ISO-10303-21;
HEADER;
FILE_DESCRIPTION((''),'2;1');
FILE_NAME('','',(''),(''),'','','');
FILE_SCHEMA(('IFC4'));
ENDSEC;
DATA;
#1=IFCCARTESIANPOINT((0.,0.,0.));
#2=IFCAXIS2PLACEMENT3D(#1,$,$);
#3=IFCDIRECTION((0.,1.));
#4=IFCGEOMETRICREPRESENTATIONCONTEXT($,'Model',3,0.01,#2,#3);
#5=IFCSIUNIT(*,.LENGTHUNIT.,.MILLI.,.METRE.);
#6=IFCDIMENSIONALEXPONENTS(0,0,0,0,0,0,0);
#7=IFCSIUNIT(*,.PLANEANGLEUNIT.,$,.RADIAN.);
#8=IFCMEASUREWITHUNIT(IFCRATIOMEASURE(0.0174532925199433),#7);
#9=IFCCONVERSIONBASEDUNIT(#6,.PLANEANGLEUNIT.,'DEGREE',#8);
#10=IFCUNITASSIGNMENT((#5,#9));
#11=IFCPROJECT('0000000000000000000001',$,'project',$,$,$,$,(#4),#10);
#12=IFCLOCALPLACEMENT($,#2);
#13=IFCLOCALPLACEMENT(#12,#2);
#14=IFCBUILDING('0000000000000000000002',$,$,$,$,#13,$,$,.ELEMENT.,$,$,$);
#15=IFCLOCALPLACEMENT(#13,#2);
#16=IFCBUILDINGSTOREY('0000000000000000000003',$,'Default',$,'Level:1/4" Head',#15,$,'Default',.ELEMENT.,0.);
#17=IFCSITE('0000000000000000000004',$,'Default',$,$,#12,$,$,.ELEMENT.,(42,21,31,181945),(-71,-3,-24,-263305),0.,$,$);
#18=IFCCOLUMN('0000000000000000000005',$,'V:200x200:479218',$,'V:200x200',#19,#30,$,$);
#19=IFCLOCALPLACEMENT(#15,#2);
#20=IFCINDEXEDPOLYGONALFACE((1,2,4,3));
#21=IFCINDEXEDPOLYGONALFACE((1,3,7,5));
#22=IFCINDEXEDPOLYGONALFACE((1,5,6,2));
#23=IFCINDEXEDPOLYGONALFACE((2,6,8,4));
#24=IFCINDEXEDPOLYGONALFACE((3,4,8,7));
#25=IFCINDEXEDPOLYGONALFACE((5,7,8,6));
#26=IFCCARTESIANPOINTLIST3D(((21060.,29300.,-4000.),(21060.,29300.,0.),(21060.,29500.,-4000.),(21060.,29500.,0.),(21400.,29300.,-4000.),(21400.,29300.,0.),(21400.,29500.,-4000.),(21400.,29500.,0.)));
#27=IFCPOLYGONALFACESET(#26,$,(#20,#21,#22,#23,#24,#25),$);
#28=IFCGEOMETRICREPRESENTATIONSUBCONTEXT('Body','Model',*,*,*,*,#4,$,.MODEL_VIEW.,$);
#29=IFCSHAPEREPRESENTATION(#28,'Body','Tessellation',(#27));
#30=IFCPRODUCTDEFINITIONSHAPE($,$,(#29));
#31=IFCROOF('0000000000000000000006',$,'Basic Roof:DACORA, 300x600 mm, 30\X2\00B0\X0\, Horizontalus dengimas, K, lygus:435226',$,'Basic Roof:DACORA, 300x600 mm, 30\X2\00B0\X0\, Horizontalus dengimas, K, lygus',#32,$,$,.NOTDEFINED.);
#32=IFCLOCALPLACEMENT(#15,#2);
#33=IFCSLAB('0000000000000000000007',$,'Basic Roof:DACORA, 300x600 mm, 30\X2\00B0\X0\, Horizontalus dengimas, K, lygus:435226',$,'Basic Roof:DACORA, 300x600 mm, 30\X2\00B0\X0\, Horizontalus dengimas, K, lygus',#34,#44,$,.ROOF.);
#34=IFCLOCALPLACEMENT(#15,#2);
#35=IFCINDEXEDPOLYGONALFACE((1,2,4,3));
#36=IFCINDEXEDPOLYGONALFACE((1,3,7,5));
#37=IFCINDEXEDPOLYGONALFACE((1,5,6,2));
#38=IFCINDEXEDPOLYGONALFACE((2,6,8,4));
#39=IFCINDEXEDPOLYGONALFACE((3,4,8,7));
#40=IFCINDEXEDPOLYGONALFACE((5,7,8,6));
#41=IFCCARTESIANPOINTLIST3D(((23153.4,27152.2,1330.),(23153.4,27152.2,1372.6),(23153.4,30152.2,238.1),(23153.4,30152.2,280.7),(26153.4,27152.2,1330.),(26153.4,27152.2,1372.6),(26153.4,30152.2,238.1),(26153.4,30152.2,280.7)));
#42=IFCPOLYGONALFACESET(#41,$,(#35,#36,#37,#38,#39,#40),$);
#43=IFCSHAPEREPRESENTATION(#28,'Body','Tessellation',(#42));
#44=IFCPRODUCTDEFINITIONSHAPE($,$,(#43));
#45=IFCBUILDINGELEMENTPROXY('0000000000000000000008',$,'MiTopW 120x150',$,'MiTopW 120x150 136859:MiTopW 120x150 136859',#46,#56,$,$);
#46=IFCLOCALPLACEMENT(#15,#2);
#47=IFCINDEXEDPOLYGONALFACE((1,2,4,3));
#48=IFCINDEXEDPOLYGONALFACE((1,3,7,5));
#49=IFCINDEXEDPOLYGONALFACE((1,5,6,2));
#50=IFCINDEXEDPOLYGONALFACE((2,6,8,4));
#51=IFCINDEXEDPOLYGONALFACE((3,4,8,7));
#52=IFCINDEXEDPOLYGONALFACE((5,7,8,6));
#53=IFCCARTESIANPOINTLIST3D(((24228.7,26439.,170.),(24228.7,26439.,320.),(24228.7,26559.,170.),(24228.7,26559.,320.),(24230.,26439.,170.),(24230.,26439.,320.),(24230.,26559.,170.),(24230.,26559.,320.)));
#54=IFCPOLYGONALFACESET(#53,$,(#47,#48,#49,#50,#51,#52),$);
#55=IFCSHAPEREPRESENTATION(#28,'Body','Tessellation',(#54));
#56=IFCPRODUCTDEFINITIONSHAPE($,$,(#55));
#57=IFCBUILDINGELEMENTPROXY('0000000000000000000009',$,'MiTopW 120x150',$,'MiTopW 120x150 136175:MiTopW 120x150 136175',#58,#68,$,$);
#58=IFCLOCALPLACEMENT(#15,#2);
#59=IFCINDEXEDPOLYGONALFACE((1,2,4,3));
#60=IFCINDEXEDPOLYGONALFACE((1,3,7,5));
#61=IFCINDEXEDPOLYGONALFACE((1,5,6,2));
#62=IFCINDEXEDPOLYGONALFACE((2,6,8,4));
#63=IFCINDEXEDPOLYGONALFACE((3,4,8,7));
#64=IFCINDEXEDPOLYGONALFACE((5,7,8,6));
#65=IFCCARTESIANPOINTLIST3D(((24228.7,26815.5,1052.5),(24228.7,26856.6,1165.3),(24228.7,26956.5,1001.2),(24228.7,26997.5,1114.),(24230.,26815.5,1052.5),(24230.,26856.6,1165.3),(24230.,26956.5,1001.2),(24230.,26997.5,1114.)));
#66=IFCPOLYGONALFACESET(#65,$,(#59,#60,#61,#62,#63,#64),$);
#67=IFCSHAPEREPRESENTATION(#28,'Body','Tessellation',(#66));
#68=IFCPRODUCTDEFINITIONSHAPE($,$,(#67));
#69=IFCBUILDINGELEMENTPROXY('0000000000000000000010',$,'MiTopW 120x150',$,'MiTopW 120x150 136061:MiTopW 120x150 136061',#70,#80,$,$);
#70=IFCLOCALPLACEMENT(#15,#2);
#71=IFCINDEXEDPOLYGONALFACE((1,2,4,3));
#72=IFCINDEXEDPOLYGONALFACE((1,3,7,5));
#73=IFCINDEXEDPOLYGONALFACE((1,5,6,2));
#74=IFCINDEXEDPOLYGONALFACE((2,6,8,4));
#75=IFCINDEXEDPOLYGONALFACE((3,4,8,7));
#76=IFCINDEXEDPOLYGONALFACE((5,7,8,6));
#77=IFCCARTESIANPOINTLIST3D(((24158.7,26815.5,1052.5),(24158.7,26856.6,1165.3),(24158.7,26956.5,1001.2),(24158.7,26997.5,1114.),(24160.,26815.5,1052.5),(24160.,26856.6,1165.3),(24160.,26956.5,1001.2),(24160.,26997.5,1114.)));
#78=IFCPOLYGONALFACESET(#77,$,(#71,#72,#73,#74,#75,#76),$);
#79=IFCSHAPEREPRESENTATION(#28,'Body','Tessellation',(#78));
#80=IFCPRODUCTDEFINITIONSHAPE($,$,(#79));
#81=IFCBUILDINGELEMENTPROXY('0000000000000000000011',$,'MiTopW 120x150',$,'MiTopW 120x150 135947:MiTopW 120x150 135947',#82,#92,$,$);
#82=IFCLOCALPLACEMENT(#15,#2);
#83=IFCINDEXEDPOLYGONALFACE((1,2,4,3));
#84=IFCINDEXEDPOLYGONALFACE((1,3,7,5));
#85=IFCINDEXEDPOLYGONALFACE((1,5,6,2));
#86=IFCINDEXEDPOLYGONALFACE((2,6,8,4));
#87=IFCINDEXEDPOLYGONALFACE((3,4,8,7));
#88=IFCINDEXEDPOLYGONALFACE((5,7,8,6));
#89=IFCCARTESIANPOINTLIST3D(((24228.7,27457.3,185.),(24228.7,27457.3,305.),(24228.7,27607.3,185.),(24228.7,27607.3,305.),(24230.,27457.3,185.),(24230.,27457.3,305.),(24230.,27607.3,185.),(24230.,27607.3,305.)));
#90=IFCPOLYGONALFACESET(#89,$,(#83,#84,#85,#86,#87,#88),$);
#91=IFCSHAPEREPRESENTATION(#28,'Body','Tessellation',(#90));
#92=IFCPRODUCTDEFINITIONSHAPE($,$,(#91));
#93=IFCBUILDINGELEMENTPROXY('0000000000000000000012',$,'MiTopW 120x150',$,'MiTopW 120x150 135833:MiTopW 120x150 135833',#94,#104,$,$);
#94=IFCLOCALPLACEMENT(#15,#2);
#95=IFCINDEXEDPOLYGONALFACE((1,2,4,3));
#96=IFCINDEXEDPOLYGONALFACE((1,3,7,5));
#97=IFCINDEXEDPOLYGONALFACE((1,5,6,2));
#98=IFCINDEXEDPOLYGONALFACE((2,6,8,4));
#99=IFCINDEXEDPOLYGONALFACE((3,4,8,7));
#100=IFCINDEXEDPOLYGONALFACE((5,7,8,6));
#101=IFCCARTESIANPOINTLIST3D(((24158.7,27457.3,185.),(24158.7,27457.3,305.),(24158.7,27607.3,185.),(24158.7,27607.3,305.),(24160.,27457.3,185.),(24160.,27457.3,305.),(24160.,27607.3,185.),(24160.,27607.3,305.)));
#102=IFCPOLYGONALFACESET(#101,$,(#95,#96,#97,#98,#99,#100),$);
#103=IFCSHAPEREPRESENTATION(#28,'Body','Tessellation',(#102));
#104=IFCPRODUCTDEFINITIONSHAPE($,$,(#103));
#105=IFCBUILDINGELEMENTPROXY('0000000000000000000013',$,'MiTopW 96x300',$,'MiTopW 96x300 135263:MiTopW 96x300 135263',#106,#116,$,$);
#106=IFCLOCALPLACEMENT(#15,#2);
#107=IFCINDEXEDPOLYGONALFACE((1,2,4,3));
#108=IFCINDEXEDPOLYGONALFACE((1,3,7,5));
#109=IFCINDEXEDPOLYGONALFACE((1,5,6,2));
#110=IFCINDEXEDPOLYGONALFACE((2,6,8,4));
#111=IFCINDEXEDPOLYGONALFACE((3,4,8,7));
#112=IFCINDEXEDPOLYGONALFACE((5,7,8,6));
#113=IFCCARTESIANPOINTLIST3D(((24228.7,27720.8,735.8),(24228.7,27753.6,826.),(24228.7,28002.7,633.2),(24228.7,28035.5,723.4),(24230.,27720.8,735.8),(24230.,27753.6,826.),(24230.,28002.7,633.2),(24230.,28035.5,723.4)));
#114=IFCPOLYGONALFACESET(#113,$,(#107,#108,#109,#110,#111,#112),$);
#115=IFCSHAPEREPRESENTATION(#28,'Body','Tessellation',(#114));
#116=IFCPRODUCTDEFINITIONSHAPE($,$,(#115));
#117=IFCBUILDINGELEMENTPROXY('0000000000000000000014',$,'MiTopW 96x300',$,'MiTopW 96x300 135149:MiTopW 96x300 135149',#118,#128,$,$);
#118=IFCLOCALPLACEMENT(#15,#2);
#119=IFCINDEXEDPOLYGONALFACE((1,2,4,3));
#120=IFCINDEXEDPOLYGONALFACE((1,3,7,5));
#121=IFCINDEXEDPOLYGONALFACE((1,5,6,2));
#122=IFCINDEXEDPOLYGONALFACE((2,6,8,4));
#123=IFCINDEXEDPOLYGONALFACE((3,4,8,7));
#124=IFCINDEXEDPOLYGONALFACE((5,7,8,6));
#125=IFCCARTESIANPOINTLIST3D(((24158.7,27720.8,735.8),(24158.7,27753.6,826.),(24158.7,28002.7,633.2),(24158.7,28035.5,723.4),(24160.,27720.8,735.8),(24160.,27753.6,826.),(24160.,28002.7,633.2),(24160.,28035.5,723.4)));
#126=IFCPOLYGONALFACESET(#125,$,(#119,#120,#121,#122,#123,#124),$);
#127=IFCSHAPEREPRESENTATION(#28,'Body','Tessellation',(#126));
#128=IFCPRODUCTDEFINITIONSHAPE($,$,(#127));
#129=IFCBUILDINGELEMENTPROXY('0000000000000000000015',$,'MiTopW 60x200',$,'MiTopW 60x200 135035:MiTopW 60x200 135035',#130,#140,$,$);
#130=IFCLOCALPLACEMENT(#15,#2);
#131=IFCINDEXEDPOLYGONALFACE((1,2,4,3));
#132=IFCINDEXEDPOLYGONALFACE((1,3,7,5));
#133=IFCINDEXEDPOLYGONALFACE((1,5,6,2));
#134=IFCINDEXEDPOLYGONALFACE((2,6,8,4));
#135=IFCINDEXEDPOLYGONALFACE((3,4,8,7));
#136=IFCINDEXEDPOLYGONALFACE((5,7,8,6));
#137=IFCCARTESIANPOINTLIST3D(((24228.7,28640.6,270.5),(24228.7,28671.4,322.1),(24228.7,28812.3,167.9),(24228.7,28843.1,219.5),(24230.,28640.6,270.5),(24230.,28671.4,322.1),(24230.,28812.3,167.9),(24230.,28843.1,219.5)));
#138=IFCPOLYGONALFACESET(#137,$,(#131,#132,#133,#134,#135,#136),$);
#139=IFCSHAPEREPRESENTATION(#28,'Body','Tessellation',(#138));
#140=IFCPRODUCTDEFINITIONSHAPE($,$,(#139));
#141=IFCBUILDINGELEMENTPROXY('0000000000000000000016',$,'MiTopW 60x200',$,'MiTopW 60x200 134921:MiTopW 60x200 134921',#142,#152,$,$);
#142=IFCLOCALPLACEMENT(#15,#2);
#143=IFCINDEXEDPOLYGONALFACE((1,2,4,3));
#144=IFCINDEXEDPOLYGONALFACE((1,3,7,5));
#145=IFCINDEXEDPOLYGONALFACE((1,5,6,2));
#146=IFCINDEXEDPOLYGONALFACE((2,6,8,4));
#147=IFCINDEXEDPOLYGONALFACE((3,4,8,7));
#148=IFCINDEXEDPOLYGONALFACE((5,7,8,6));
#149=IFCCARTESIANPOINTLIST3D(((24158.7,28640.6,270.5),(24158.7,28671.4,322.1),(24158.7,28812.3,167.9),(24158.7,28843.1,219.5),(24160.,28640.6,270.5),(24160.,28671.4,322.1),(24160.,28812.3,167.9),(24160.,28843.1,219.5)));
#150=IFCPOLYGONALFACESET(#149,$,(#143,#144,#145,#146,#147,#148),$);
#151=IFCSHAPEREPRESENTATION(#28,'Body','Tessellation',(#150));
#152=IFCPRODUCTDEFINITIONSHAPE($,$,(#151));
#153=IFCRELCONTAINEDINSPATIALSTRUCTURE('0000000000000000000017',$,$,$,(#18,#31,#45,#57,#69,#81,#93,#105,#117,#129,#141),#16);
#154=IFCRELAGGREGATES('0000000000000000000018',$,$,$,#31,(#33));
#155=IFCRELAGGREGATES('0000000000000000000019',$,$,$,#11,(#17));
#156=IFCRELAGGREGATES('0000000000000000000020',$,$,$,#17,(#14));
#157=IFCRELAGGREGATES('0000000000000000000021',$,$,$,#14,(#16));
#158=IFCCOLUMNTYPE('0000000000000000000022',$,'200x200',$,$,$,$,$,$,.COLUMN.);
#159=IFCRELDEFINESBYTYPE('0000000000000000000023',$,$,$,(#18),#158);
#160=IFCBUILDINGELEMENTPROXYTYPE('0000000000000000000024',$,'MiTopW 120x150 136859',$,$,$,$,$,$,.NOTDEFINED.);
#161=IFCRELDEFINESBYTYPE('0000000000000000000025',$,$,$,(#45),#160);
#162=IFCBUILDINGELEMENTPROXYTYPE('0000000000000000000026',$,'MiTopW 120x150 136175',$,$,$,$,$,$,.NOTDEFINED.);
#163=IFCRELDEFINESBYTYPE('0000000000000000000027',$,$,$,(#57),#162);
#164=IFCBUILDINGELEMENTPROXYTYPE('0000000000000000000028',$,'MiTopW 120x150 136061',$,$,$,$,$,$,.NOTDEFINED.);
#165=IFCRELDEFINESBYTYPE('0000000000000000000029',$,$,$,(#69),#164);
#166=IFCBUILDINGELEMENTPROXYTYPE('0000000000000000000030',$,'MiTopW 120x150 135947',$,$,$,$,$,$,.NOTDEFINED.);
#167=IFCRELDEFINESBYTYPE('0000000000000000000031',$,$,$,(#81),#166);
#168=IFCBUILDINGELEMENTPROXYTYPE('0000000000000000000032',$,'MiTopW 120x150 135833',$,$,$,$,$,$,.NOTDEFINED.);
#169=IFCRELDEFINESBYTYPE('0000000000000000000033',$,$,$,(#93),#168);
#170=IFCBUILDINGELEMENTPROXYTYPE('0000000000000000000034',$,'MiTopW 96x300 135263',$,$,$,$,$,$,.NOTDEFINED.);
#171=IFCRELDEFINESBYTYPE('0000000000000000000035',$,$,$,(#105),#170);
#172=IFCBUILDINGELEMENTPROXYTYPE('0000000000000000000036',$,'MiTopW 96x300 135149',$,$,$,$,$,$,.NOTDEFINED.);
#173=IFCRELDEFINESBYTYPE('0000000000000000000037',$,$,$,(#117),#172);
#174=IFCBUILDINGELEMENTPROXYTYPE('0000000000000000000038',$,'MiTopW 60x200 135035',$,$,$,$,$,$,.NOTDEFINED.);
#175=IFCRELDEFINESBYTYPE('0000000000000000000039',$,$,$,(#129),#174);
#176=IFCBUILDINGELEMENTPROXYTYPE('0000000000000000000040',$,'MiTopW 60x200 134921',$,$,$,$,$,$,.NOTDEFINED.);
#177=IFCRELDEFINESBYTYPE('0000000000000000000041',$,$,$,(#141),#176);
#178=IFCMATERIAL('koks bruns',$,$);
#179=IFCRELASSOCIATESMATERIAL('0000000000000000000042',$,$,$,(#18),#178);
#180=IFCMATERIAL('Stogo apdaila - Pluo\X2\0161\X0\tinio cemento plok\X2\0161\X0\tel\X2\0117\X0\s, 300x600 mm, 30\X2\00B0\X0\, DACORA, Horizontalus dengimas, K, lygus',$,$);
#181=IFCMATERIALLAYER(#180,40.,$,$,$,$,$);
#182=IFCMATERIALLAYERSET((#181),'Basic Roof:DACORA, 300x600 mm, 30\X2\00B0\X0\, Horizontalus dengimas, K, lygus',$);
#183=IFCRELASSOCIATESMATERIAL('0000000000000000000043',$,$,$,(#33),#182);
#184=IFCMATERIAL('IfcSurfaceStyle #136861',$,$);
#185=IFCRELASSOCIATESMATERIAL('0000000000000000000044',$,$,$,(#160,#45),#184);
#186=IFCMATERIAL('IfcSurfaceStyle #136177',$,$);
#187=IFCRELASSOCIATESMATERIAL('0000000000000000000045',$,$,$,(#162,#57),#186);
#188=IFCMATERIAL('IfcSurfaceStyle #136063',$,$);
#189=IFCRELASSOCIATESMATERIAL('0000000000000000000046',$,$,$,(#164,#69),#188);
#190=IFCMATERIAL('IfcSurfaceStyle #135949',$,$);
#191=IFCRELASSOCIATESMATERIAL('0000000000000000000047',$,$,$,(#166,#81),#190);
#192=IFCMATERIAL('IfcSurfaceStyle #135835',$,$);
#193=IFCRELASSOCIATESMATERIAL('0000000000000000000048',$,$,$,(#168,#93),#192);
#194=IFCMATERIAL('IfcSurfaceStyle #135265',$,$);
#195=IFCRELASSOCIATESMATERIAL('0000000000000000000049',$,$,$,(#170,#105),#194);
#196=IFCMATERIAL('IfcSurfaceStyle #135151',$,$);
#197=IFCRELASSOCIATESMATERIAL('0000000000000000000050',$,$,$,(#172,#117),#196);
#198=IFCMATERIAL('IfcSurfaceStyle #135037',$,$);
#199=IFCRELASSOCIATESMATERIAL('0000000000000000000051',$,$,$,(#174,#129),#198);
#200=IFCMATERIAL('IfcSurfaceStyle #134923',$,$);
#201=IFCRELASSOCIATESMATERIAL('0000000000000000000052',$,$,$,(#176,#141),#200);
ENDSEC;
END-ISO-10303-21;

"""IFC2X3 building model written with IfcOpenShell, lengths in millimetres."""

from ifc_helpers import new_model, entity, si_unit, converted_unit, direction, frame, frame_2d, origin, origin_2d_with_axis, place, context, subcontext, project, spatial, polyline, rectangle, outline, extrude, source, transform, mapped, material, layer, layer_set, type_object, type_shapes, element, aggregate, save


model = new_model("IFC2X3")

# Units and contexts
model_context = context("Model", 3, precision=0.01, world=origin(), true_north=direction((0.0, 1.0)))
body_context = subcontext(model_context, "Body", "Model", "MODEL_VIEW")
ifc_project = project(units=[si_unit("LENGTHUNIT", "METRE", prefix="MILLI"), converted_unit("PLANEANGLEUNIT", "DEGREE", entity("IfcRatioMeasure", 0.0174532925199433), si_unit("PLANEANGLEUNIT", "RADIAN"), dimensions=[0, 0, 0, 0, 0, 0, 0])], contexts=[model_context])

# Site, building, storey
site_placement = place(None, origin())
site = spatial("IfcSite", under=ifc_project, at=site_placement, Name="Default", CompositionType="ELEMENT", RefLatitude=(42, 21, 31, 181945), RefLongitude=(-71, -3, -24, -263305), RefElevation=0.0)
building_placement = place(site_placement, origin())
building = spatial("IfcBuilding", under=site, at=building_placement, CompositionType="ELEMENT")
storey_placement = place(building_placement, origin())
storey = spatial("IfcBuildingStorey", under=building, at=storey_placement, Name="Default", ObjectType="Level:1/4\" Head", LongName="Default", CompositionType="ELEMENT", Elevation=0.0)

# Column
ifc_material_1 = material(Name="koks bruns")
column_type = type_object("IfcColumnType", Name="200x200", PredefinedType="COLUMN")
shared_shape_1 = source(origin(), body_context, "Body", "SweptSolid", [
    extrude(rectangle(XDim=340.0, YDim=200.0, at=origin_2d_with_axis()), frame((100.0, 280.0, -4000.0), z_axis=(0.0, 0.0, 1.0), x_axis=(0.0, -1.0, 0.0)), (0.0, 0.0, 1.0), 4000.0),
])
type_shapes(column_type, [shared_shape_1])
column_placement = place(storey_placement, frame((21510.0, 29300.0, 0.0), z_axis=(0.0, 0.0, 1.0), x_axis=(0.0, 1.0, 0.0)))
element("IfcColumn", 1, at=column_placement, inside=storey, type_object=column_type, material=ifc_material_1, Name="V:200x200:479218", ObjectType="V:200x200", context=body_context, shape_type="MappedRepresentation", body=[
    mapped(shared_shape_1, transform((0.0, 0.0, 0.0), scale=1.0)),
])

# Roof, slab
roof_placement = place(storey_placement, frame((23153.4, 27152.2, 238.1)))
roof = element("IfcRoof", 2, at=roof_placement, inside=storey, Name="Basic Roof:DACORA, 300x600 mm, 30°, Horizontalus dengimas, K, lygus:435226", ObjectType="Basic Roof:DACORA, 300x600 mm, 30°, Horizontalus dengimas, K, lygus", ShapeType="NOTDEFINED")
ifc_material_2 = material(Name="Stogo apdaila - Pluoštinio cemento plokštelės, 300x600 mm, 30°, DACORA, Horizontalus dengimas, K, lygus")
ifc_layer = layer(ifc_material_2, 40.0)
ifc_layer_set = layer_set([ifc_layer], Name="Basic Roof:DACORA, 300x600 mm, 30°, Horizontalus dengimas, K, lygus")
slab_placement = place(roof_placement, origin())
slab = element("IfcSlab", 3, at=slab_placement, material=ifc_layer_set, Name="Basic Roof:DACORA, 300x600 mm, 30°, Horizontalus dengimas, K, lygus:435226", ObjectType="Basic Roof:DACORA, 300x600 mm, 30°, Horizontalus dengimas, K, lygus", PredefinedType="ROOF", context=body_context, shape_type="SweptSolid", body=[
    extrude(rectangle(XDim=3192.5, YDim=3000.0, at=frame_2d((0.0, 0.0), x_axis=(0.0, 1.0))), frame((1500.0, 1500.0, 546.0), z_axis=(0.0, 0.34202, 0.939693), x_axis=(1.0, 0.0, 0.0)), (0.0, -0.34202, 0.939693), 42.6),
])
aggregate(roof, [slab])

# Building element proxies
ifc_material_3 = material(Name="IfcSurfaceStyle #136861")
building_element_proxy_type_1 = type_object("IfcBuildingElementProxyType", Name="MiTopW 120x150 136859", PredefinedType="NOTDEFINED", material=ifc_material_3)
shared_shape_2 = source(origin(), body_context, "Body", "SweptSolid", [
    extrude(rectangle(XDim=150.0, YDim=120.0, at=frame_2d((0.0, 0.0), x_axis=(1.0, 0.0))), frame((75.0, 60.0, 0.0), z_axis=(0.0, 0.0, 1.0), x_axis=(-1.0, 0.0, 0.0)), (0.0, 0.0, 1.0), 1.3),
])
type_shapes(building_element_proxy_type_1, [shared_shape_2])
proxy_1_placement = place(building_placement, frame((24230.0, 26439.0, 170.0), z_axis=(-1.0, 0.0, 0.0), x_axis=(0.0, 0.0, 1.0)))
element("IfcBuildingElementProxy", 4, at=proxy_1_placement, inside=storey, type_object=building_element_proxy_type_1, material=ifc_material_3, Name="MiTopW 120x150", ObjectType="MiTopW 120x150 136859:MiTopW 120x150 136859", context=body_context, shape_type="MappedRepresentation", body=[
    mapped(shared_shape_2, transform((0.0, 0.0, 0.0), scale=1.0)),
])
ifc_material_4 = material(Name="IfcSurfaceStyle #136177")
building_element_proxy_type_2 = type_object("IfcBuildingElementProxyType", Name="MiTopW 120x150 136175", PredefinedType="NOTDEFINED", material=ifc_material_4)
shared_shape_3 = source(origin(), body_context, "Body", "SweptSolid", [
    extrude(outline(polyline([(-75.0, -60.0), (75.0, -60.0), (75.0, 60.0), (-75.0, 60.0), (-75.0, -60.0)])), frame((75.0, 60.0, 0.0), z_axis=(0.0, 0.0, 1.0), x_axis=(-1.0, 0.0, 0.0)), (0.0, 0.0, 1.0), 1.3),
])
type_shapes(building_element_proxy_type_2, [shared_shape_3])
proxy_2_placement = place(building_placement, frame((24230.0, 26956.5, 1001.2), z_axis=(-1.0, 0.0, 0.0), x_axis=(0.0, -0.939693, 0.34202)))
element("IfcBuildingElementProxy", 5, at=proxy_2_placement, inside=storey, type_object=building_element_proxy_type_2, material=ifc_material_4, Name="MiTopW 120x150", ObjectType="MiTopW 120x150 136175:MiTopW 120x150 136175", context=body_context, shape_type="MappedRepresentation", body=[
    mapped(shared_shape_3, transform((0.0, 0.0, 0.0), scale=1.0)),
])
ifc_material_5 = material(Name="IfcSurfaceStyle #136063")
building_element_proxy_type_3 = type_object("IfcBuildingElementProxyType", Name="MiTopW 120x150 136061", PredefinedType="NOTDEFINED", material=ifc_material_5)
shared_shape_4 = source(origin(), body_context, "Body", "SweptSolid", [
    extrude(outline(polyline([(-75.0, -60.0), (75.0, -60.0), (75.0, 60.0), (-75.0, 60.0), (-75.0, -60.0)])), frame((75.0, 60.0, 0.0), z_axis=(0.0, 0.0, 1.0), x_axis=(-1.0, 0.0, 0.0)), (0.0, 0.0, 1.0), 1.3),
])
type_shapes(building_element_proxy_type_3, [shared_shape_4])
proxy_3_placement = place(building_placement, frame((24160.0, 26956.5, 1001.2), z_axis=(-1.0, 0.0, 0.0), x_axis=(0.0, -0.939693, 0.34202)))
element("IfcBuildingElementProxy", 6, at=proxy_3_placement, inside=storey, type_object=building_element_proxy_type_3, material=ifc_material_5, Name="MiTopW 120x150", ObjectType="MiTopW 120x150 136061:MiTopW 120x150 136061", context=body_context, shape_type="MappedRepresentation", body=[
    mapped(shared_shape_4, transform((0.0, 0.0, 0.0), scale=1.0)),
])
ifc_material_6 = material(Name="IfcSurfaceStyle #135949")
building_element_proxy_type_4 = type_object("IfcBuildingElementProxyType", Name="MiTopW 120x150 135947", PredefinedType="NOTDEFINED", material=ifc_material_6)
shared_shape_5 = source(origin(), body_context, "Body", "SweptSolid", [
    extrude(rectangle(XDim=150.0, YDim=120.0, at=origin_2d_with_axis()), frame((75.0, 60.0, 0.0), z_axis=(0.0, 0.0, 1.0), x_axis=(-1.0, 0.0, 0.0)), (0.0, 0.0, 1.0), 1.3),
])
type_shapes(building_element_proxy_type_4, [shared_shape_5])
proxy_4_placement = place(building_placement, frame((24230.0, 27607.3, 185.0), z_axis=(-1.0, 0.0, 0.0), x_axis=(0.0, -1.0, 0.0)))
element("IfcBuildingElementProxy", 7, at=proxy_4_placement, inside=storey, type_object=building_element_proxy_type_4, material=ifc_material_6, Name="MiTopW 120x150", ObjectType="MiTopW 120x150 135947:MiTopW 120x150 135947", context=body_context, shape_type="MappedRepresentation", body=[
    mapped(shared_shape_5, transform((0.0, 0.0, 0.0), scale=1.0)),
])
ifc_material_7 = material(Name="IfcSurfaceStyle #135835")
building_element_proxy_type_5 = type_object("IfcBuildingElementProxyType", Name="MiTopW 120x150 135833", PredefinedType="NOTDEFINED", material=ifc_material_7)
shared_shape_6 = source(origin(), body_context, "Body", "SweptSolid", [
    extrude(rectangle(XDim=150.0, YDim=120.0, at=origin_2d_with_axis()), frame((75.0, 60.0, 0.0), z_axis=(0.0, 0.0, 1.0), x_axis=(-1.0, 0.0, 0.0)), (0.0, 0.0, 1.0), 1.3),
])
type_shapes(building_element_proxy_type_5, [shared_shape_6])
proxy_5_placement = place(building_placement, frame((24160.0, 27607.3, 185.0), z_axis=(-1.0, 0.0, 0.0), x_axis=(0.0, -1.0, 0.0)))
element("IfcBuildingElementProxy", 8, at=proxy_5_placement, inside=storey, type_object=building_element_proxy_type_5, material=ifc_material_7, Name="MiTopW 120x150", ObjectType="MiTopW 120x150 135833:MiTopW 120x150 135833", context=body_context, shape_type="MappedRepresentation", body=[
    mapped(shared_shape_6, transform((0.0, 0.0, 0.0), scale=1.0)),
])
ifc_material_8 = material(Name="IfcSurfaceStyle #135265")
building_element_proxy_type_6 = type_object("IfcBuildingElementProxyType", Name="MiTopW 96x300 135263", PredefinedType="NOTDEFINED", material=ifc_material_8)
shared_shape_7 = source(origin(), body_context, "Body", "SweptSolid", [
    extrude(outline(polyline([(-150.0, -48.0), (150.0, -48.0), (150.0, 48.0), (-150.0, 48.0), (-150.0, -48.0)])), frame((150.0, 48.0, 0.0), z_axis=(0.0, 0.0, 1.0), x_axis=(-1.0, 0.0, 0.0)), (0.0, 0.0, 1.0), 1.3),
])
type_shapes(building_element_proxy_type_6, [shared_shape_7])
proxy_6_placement = place(building_placement, frame((24230.0, 28002.7, 633.2), z_axis=(-1.0, 0.0, 0.0), x_axis=(0.0, -0.939693, 0.34202)))
element("IfcBuildingElementProxy", 9, at=proxy_6_placement, inside=storey, type_object=building_element_proxy_type_6, material=ifc_material_8, Name="MiTopW 96x300", ObjectType="MiTopW 96x300 135263:MiTopW 96x300 135263", context=body_context, shape_type="MappedRepresentation", body=[
    mapped(shared_shape_7, transform((0.0, 0.0, 0.0), scale=1.0)),
])
ifc_material_9 = material(Name="IfcSurfaceStyle #135151")
building_element_proxy_type_7 = type_object("IfcBuildingElementProxyType", Name="MiTopW 96x300 135149", PredefinedType="NOTDEFINED", material=ifc_material_9)
shared_shape_8 = source(origin(), body_context, "Body", "SweptSolid", [
    extrude(outline(polyline([(-150.0, -48.0), (150.0, -48.0), (150.0, 48.0), (-150.0, 48.0), (-150.0, -48.0)])), frame((150.0, 48.0, 0.0), z_axis=(0.0, 0.0, 1.0), x_axis=(-1.0, 0.0, 0.0)), (0.0, 0.0, 1.0), 1.3),
])
type_shapes(building_element_proxy_type_7, [shared_shape_8])
proxy_7_placement = place(building_placement, frame((24160.0, 28002.7, 633.2), z_axis=(-1.0, 0.0, 0.0), x_axis=(0.0, -0.939693, 0.34202)))
element("IfcBuildingElementProxy", 10, at=proxy_7_placement, inside=storey, type_object=building_element_proxy_type_7, material=ifc_material_9, Name="MiTopW 96x300", ObjectType="MiTopW 96x300 135149:MiTopW 96x300 135149", context=body_context, shape_type="MappedRepresentation", body=[
    mapped(shared_shape_8, transform((0.0, 0.0, 0.0), scale=1.0)),
])
ifc_material_10 = material(Name="IfcSurfaceStyle #135037")
building_element_proxy_type_8 = type_object("IfcBuildingElementProxyType", Name="MiTopW 60x200 135035", PredefinedType="NOTDEFINED", material=ifc_material_10)
shared_shape_9 = source(origin(), body_context, "Body", "SweptSolid", [
    extrude(outline(polyline([(-100.0, -30.0), (100.0, -30.0), (100.0, 30.0), (-100.0, 30.0), (-100.0, -30.0)])), frame((100.0, 30.0, 0.0), z_axis=(0.0, 0.0, 1.0), x_axis=(-1.0, 0.0, 0.0)), (0.0, 0.0, 1.0), 1.3),
])
type_shapes(building_element_proxy_type_8, [shared_shape_9])
proxy_8_placement = place(building_placement, frame((24230.0, 28812.3, 167.9), z_axis=(-1.0, 0.0, 0.0), x_axis=(0.0, -0.858392, 0.512994)))
element("IfcBuildingElementProxy", 11, at=proxy_8_placement, inside=storey, type_object=building_element_proxy_type_8, material=ifc_material_10, Name="MiTopW 60x200", ObjectType="MiTopW 60x200 135035:MiTopW 60x200 135035", context=body_context, shape_type="MappedRepresentation", body=[
    mapped(shared_shape_9, transform((0.0, 0.0, 0.0), scale=1.0)),
])
ifc_material_11 = material(Name="IfcSurfaceStyle #134923")
building_element_proxy_type_9 = type_object("IfcBuildingElementProxyType", Name="MiTopW 60x200 134921", PredefinedType="NOTDEFINED", material=ifc_material_11)
shared_shape_10 = source(origin(), body_context, "Body", "SweptSolid", [
    extrude(outline(polyline([(-100.0, -30.0), (100.0, -30.0), (100.0, 30.0), (-100.0, 30.0), (-100.0, -30.0)])), frame((100.0, 30.0, 0.0), z_axis=(0.0, 0.0, 1.0), x_axis=(-1.0, 0.0, 0.0)), (0.0, 0.0, 1.0), 1.3),
])
type_shapes(building_element_proxy_type_9, [shared_shape_10])
proxy_9_placement = place(building_placement, frame((24160.0, 28812.3, 167.9), z_axis=(-1.0, 0.0, 0.0), x_axis=(0.0, -0.858392, 0.512994)))
element("IfcBuildingElementProxy", 12, at=proxy_9_placement, inside=storey, type_object=building_element_proxy_type_9, material=ifc_material_11, Name="MiTopW 60x200", ObjectType="MiTopW 60x200 134921:MiTopW 60x200 134921", context=body_context, shape_type="MappedRepresentation", body=[
    mapped(shared_shape_10, transform((0.0, 0.0, 0.0), scale=1.0)),
])

save(model, "model.ifc")
